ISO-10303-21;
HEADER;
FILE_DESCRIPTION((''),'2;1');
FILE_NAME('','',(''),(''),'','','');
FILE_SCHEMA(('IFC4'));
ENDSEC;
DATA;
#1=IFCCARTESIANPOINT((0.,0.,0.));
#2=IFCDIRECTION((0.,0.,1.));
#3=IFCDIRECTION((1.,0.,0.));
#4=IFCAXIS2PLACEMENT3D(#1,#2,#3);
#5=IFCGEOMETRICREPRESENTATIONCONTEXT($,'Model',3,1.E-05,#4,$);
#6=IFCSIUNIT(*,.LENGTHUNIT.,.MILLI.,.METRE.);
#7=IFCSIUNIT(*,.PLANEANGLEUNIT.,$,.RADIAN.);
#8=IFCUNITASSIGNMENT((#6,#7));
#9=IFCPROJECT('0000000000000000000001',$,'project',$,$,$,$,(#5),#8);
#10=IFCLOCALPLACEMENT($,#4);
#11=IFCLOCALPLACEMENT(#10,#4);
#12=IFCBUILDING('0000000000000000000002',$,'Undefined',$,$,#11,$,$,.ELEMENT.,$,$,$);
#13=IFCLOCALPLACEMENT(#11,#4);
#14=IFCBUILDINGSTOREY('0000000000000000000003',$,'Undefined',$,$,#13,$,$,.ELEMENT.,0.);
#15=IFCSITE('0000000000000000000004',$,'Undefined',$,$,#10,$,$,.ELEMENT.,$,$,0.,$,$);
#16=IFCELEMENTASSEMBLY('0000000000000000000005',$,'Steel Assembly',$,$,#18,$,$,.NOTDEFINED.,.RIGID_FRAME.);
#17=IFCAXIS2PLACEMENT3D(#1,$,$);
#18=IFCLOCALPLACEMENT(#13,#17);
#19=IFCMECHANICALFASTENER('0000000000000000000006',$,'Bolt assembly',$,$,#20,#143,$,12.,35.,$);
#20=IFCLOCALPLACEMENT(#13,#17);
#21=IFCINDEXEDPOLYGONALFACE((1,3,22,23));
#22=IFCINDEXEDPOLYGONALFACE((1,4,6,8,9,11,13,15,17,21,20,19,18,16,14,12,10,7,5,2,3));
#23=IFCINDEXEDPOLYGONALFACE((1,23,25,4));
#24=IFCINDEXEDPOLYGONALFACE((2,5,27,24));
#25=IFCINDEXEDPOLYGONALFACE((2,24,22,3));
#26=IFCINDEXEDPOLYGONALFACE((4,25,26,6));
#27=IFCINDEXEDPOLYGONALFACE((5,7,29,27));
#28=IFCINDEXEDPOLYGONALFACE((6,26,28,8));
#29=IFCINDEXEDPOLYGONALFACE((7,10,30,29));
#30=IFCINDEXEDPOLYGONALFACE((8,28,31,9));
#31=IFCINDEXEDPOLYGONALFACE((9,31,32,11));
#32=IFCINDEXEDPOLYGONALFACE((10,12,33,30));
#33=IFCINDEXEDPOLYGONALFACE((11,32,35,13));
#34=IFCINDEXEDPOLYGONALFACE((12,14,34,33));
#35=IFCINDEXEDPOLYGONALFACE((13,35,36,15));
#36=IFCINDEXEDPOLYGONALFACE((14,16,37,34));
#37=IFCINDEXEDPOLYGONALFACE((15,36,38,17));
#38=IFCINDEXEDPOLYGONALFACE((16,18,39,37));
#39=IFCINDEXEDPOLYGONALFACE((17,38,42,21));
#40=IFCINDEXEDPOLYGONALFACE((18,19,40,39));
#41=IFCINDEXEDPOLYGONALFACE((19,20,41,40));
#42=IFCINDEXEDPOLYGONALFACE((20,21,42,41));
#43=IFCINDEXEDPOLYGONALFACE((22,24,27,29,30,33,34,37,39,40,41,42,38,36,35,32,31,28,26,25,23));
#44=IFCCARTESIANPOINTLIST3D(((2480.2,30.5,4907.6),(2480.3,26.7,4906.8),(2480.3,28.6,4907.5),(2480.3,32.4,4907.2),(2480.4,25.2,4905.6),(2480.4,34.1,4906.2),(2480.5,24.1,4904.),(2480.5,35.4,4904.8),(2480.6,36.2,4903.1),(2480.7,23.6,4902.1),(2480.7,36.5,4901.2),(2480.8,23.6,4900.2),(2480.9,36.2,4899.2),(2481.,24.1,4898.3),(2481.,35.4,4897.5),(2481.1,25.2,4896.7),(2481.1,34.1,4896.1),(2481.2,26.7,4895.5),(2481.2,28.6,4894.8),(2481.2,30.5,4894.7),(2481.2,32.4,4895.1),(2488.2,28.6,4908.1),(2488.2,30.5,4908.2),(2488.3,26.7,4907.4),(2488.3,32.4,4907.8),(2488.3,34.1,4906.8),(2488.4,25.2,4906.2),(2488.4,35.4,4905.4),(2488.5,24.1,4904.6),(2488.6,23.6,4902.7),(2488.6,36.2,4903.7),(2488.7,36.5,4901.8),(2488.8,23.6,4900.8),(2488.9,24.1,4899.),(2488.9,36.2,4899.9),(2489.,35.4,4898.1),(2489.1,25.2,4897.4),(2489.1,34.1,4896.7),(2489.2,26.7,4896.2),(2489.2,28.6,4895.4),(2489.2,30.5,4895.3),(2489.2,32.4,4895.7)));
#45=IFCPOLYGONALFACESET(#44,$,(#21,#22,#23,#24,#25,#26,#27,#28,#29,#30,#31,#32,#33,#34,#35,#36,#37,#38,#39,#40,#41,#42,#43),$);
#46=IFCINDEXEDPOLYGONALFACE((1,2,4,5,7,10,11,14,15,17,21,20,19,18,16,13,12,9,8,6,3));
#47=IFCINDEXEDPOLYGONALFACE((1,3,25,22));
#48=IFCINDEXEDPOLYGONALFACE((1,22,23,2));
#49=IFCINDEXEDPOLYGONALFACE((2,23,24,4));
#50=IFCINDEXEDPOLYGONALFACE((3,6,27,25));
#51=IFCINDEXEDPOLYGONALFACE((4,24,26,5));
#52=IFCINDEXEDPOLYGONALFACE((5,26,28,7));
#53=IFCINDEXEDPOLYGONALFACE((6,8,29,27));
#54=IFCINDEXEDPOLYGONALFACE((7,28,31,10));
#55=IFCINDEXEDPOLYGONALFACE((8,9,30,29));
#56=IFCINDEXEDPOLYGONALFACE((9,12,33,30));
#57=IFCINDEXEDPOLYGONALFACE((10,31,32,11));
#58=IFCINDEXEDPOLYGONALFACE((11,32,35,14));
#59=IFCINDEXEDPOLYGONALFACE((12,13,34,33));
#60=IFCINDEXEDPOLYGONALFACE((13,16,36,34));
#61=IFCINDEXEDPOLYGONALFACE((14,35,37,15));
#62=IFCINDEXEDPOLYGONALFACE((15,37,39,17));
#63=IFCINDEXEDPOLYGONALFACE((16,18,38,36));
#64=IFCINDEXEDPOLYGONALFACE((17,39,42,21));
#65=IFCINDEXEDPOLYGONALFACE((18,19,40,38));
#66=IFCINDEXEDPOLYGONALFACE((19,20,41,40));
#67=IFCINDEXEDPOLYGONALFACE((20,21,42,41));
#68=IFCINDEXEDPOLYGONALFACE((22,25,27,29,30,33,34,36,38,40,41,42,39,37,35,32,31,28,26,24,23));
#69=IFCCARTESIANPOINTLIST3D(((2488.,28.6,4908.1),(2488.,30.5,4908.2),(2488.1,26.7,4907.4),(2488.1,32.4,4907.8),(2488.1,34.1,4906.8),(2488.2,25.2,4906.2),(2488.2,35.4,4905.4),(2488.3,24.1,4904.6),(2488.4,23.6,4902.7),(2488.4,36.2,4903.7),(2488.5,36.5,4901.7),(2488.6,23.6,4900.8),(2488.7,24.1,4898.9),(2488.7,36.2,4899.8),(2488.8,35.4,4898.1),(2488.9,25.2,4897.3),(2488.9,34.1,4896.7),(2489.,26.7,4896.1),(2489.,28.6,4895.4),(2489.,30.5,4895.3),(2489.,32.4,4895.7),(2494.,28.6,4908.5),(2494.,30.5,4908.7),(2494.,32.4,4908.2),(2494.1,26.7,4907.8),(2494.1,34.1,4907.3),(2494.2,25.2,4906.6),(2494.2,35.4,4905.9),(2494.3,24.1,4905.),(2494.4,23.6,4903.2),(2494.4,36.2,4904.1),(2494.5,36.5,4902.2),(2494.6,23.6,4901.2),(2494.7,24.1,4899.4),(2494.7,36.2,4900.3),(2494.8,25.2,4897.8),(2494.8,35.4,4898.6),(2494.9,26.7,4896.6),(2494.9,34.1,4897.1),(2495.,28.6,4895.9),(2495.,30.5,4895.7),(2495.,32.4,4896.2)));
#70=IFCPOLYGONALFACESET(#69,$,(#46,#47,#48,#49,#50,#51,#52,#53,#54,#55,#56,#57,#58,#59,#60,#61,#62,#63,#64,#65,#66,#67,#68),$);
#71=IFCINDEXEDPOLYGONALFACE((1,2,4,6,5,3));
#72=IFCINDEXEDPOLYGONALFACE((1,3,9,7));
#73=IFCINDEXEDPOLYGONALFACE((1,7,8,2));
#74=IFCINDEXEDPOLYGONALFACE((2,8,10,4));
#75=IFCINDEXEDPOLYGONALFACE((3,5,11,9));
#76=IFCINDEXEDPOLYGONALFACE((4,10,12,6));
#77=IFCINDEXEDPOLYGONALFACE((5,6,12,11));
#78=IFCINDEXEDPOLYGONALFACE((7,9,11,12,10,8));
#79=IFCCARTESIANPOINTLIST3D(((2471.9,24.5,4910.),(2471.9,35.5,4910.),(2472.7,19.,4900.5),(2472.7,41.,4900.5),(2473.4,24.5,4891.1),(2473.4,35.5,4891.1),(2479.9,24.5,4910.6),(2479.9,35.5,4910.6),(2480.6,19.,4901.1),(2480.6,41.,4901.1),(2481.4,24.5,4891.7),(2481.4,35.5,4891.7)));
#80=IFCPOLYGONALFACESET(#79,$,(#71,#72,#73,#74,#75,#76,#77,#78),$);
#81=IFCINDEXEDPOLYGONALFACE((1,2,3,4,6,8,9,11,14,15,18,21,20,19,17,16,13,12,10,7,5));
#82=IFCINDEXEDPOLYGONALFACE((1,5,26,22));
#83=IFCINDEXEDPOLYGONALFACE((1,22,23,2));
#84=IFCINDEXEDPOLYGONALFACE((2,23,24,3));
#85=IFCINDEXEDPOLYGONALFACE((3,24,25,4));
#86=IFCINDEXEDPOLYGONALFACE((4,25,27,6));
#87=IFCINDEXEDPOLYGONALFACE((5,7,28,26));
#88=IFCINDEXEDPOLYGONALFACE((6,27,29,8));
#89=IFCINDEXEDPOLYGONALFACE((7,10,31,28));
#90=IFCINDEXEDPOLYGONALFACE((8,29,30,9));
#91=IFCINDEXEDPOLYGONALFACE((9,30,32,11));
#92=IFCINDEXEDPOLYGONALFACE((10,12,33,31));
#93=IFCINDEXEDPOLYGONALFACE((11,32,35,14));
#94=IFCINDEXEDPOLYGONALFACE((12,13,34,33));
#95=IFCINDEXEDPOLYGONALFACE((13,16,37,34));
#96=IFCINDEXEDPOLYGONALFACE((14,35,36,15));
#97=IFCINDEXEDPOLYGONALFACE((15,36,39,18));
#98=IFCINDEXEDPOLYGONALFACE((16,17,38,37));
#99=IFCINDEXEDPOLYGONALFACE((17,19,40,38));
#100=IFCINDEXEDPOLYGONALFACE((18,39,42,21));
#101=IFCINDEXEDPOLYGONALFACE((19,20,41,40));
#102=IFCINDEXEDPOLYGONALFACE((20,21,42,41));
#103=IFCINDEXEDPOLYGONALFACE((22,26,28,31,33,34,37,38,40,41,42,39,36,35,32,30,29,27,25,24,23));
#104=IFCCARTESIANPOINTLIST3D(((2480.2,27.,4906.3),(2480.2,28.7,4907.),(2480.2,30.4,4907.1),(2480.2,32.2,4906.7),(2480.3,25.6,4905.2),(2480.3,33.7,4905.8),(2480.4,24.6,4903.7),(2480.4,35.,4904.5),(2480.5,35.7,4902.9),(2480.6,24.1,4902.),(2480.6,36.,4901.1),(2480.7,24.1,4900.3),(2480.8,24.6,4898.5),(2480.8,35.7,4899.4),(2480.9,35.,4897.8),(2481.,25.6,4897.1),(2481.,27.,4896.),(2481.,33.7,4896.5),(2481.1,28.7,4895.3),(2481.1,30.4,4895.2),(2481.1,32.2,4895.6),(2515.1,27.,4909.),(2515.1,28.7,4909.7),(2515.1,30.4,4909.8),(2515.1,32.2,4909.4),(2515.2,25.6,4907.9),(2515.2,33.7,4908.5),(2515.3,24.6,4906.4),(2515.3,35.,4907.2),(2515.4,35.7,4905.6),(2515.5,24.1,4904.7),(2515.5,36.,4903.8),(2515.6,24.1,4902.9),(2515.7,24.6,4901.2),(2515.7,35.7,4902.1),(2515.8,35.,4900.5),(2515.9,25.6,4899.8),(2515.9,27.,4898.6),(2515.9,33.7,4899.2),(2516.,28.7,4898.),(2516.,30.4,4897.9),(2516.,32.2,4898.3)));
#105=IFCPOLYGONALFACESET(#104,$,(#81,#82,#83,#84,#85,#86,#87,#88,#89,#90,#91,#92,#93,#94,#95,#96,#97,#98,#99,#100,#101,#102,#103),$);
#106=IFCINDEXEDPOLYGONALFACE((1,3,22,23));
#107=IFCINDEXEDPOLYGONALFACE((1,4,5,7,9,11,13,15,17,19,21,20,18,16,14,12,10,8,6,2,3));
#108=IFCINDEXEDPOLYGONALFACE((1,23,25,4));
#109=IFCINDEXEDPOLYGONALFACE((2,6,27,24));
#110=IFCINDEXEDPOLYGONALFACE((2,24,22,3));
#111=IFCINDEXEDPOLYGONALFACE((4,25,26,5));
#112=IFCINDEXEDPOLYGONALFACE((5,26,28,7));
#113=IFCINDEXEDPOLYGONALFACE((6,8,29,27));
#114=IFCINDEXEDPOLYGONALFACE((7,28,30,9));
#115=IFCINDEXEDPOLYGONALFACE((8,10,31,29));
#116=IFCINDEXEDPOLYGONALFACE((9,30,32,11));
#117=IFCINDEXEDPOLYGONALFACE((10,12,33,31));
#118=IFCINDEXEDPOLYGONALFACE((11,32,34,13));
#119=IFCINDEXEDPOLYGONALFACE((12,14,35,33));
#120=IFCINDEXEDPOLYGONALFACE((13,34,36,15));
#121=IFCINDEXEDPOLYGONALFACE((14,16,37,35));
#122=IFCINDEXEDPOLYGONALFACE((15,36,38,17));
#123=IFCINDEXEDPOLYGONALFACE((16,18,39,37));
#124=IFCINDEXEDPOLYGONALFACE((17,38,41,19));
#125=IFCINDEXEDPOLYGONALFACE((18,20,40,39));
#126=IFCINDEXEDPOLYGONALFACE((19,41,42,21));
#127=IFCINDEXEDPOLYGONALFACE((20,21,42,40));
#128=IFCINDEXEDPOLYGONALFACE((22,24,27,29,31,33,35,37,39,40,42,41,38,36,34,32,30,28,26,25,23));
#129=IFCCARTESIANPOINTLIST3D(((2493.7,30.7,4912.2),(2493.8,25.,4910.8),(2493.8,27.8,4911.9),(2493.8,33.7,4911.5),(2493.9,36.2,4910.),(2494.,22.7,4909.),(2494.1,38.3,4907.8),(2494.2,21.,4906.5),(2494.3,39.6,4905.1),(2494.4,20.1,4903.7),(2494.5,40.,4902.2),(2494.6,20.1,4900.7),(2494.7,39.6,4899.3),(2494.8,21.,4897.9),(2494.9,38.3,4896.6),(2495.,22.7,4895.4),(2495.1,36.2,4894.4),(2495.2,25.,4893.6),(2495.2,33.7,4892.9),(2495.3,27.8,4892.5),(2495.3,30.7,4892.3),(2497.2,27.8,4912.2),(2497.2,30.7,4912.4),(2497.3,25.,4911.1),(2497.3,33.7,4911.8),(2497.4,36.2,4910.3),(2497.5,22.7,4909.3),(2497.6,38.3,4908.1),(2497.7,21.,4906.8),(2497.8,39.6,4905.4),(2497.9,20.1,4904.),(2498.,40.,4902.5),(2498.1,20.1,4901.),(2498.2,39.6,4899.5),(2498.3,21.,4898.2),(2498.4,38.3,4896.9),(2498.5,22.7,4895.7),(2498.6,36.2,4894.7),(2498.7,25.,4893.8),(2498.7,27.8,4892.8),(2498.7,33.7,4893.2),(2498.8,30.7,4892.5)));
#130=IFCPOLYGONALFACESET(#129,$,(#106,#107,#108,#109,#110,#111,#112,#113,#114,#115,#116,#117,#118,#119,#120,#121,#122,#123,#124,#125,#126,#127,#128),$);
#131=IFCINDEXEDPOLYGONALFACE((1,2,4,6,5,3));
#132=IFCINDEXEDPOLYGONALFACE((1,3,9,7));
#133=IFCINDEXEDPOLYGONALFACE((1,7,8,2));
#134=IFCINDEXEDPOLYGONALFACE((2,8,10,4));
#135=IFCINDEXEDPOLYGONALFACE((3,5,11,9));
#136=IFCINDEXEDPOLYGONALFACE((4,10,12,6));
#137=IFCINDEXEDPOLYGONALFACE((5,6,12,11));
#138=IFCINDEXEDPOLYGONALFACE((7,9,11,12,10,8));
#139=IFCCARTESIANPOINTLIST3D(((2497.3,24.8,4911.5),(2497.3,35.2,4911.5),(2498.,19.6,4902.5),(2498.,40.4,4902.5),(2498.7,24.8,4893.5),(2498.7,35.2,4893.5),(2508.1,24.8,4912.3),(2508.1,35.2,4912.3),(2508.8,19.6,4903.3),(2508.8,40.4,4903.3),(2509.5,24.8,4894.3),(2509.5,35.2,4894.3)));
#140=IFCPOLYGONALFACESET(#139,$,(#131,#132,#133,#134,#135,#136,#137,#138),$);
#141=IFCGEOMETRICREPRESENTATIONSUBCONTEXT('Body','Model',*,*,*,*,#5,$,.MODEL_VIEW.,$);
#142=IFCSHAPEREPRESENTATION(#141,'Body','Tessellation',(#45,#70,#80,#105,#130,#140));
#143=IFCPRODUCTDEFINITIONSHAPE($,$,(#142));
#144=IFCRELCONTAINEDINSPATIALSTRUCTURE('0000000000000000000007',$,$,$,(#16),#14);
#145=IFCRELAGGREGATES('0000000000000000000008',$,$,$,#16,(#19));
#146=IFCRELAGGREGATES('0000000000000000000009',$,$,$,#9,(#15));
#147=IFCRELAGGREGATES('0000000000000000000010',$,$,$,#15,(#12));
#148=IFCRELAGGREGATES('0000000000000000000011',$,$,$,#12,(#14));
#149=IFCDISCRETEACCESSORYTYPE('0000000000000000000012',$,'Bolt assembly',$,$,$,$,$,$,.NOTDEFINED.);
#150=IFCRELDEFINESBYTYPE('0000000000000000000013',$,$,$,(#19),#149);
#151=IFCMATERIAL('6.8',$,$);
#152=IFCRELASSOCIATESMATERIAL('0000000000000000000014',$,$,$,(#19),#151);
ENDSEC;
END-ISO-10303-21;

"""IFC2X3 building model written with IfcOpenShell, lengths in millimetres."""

from ifc_helpers import new_model, si_unit, frame, origin_with_axes, origin_2d_with_axis, place, context, subcontext, project, spatial, polyline, circle, outline, extrude, source, transform, mapped, material, type_object, element, aggregate, save


model = new_model("IFC2X3")

# Units and contexts
model_context = context("Model", 3, precision=1e-05, world=origin_with_axes())
body_context = subcontext(model_context, "Body", "Model", "MODEL_VIEW")
ifc_project = project(units=[si_unit("LENGTHUNIT", "METRE", prefix="MILLI"), si_unit("PLANEANGLEUNIT", "RADIAN")], contexts=[model_context])

# Site, building, storey
site_placement = place(None, origin_with_axes())
site = spatial("IfcSite", under=ifc_project, at=site_placement, Name="Undefined", CompositionType="ELEMENT", RefElevation=0.0)
building_placement = place(site_placement, origin_with_axes())
building = spatial("IfcBuilding", under=site, at=building_placement, Name="Undefined", CompositionType="ELEMENT")
storey_placement = place(building_placement, origin_with_axes())
storey = spatial("IfcBuildingStorey", under=building, at=storey_placement, Name="Undefined", CompositionType="ELEMENT", Elevation=0.0)

# Element assembly, mechanical fastener
ifc_material_1 = material(Name="6.8")
discrete_accessory_type_1 = type_object("IfcDiscreteAccessoryType", Name="Bolt assembly")
assembly_1_placement = place(storey_placement, origin_with_axes())
assembly_1 = element("IfcElementAssembly", 1, at=assembly_1_placement, inside=storey, Name="Steel Assembly", AssemblyPlace="NOTDEFINED", PredefinedType="RIGID_FRAME")
shared_shape_1 = source(origin_with_axes(), body_context, "Body", "SweptSolid", [
    extrude(circle(Radius=6.5, at=origin_2d_with_axis()), frame((0.0, -10.9, 0.0), z_axis=(0.0, 1.0, 0.0), x_axis=(1.0, 0.0, 0.0)), (0.0, 0.0, 1.0), 8.0),
    extrude(circle(Radius=6.5, at=origin_2d_with_axis()), frame((0.0, -3.1, 0.0), z_axis=(0.0, 1.0, 0.0), x_axis=(1.0, 0.0, 0.0)), (0.0, 0.0, 1.0), 6.0),
    extrude(outline(polyline([(11.0, 0.0), (5.5, 9.5), (-5.5, 9.5), (-11.0, 0.0), (-5.5, -9.5), (5.5, -9.5), (11.0, 0.0)])), frame((0.0, -19.0, 0.0), z_axis=(0.0, 1.0, 0.0), x_axis=(1.0, 0.0, 0.0)), (0.0, 0.0, 1.0), 8.0),
    extrude(circle(Radius=6.0, at=origin_2d_with_axis()), frame((0.0, -11.0, 0.0), z_axis=(0.0, 1.0, 0.0), x_axis=(1.0, 0.0, 0.0)), (0.0, 0.0, 1.0), 35.0),
    extrude(circle(Radius=10.0, at=origin_2d_with_axis()), frame((0.0, 3.0, 0.0), z_axis=(0.0, 1.0, 0.0), x_axis=(1.0, 0.0, 0.0)), (0.0, 0.0, 1.0), 3.5),
    extrude(outline(polyline([(10.4, 0.0), (5.2, 9.0), (-5.2, 9.0), (-10.4, 0.0), (-5.2, -9.0), (5.2, -9.0), (10.4, 0.0)])), frame((0.0, 6.5, 0.0), z_axis=(0.0, 1.0, 0.0), x_axis=(1.0, 0.0, 0.0)), (0.0, 0.0, 1.0), 10.8),
])
mechanical_fastener_1_placement = place(assembly_1_placement, frame((2491.6, 30.0, 4902.0), z_axis=(0.076696, 0.0, -0.997054), x_axis=(0.0, 1.0, 0.0)))
mechanical_fastener_1 = element("IfcMechanicalFastener", 2, at=mechanical_fastener_1_placement, type_object=discrete_accessory_type_1, material=ifc_material_1, Name="Bolt assembly", NominalDiameter=12.0, NominalLength=35.0, context=body_context, shape_type="MappedRepresentation", body=[
    mapped(shared_shape_1, transform((0.0, 0.0, 0.0))),
])
aggregate(assembly_1, [mechanical_fastener_1])

save(model, "model.ifc")
